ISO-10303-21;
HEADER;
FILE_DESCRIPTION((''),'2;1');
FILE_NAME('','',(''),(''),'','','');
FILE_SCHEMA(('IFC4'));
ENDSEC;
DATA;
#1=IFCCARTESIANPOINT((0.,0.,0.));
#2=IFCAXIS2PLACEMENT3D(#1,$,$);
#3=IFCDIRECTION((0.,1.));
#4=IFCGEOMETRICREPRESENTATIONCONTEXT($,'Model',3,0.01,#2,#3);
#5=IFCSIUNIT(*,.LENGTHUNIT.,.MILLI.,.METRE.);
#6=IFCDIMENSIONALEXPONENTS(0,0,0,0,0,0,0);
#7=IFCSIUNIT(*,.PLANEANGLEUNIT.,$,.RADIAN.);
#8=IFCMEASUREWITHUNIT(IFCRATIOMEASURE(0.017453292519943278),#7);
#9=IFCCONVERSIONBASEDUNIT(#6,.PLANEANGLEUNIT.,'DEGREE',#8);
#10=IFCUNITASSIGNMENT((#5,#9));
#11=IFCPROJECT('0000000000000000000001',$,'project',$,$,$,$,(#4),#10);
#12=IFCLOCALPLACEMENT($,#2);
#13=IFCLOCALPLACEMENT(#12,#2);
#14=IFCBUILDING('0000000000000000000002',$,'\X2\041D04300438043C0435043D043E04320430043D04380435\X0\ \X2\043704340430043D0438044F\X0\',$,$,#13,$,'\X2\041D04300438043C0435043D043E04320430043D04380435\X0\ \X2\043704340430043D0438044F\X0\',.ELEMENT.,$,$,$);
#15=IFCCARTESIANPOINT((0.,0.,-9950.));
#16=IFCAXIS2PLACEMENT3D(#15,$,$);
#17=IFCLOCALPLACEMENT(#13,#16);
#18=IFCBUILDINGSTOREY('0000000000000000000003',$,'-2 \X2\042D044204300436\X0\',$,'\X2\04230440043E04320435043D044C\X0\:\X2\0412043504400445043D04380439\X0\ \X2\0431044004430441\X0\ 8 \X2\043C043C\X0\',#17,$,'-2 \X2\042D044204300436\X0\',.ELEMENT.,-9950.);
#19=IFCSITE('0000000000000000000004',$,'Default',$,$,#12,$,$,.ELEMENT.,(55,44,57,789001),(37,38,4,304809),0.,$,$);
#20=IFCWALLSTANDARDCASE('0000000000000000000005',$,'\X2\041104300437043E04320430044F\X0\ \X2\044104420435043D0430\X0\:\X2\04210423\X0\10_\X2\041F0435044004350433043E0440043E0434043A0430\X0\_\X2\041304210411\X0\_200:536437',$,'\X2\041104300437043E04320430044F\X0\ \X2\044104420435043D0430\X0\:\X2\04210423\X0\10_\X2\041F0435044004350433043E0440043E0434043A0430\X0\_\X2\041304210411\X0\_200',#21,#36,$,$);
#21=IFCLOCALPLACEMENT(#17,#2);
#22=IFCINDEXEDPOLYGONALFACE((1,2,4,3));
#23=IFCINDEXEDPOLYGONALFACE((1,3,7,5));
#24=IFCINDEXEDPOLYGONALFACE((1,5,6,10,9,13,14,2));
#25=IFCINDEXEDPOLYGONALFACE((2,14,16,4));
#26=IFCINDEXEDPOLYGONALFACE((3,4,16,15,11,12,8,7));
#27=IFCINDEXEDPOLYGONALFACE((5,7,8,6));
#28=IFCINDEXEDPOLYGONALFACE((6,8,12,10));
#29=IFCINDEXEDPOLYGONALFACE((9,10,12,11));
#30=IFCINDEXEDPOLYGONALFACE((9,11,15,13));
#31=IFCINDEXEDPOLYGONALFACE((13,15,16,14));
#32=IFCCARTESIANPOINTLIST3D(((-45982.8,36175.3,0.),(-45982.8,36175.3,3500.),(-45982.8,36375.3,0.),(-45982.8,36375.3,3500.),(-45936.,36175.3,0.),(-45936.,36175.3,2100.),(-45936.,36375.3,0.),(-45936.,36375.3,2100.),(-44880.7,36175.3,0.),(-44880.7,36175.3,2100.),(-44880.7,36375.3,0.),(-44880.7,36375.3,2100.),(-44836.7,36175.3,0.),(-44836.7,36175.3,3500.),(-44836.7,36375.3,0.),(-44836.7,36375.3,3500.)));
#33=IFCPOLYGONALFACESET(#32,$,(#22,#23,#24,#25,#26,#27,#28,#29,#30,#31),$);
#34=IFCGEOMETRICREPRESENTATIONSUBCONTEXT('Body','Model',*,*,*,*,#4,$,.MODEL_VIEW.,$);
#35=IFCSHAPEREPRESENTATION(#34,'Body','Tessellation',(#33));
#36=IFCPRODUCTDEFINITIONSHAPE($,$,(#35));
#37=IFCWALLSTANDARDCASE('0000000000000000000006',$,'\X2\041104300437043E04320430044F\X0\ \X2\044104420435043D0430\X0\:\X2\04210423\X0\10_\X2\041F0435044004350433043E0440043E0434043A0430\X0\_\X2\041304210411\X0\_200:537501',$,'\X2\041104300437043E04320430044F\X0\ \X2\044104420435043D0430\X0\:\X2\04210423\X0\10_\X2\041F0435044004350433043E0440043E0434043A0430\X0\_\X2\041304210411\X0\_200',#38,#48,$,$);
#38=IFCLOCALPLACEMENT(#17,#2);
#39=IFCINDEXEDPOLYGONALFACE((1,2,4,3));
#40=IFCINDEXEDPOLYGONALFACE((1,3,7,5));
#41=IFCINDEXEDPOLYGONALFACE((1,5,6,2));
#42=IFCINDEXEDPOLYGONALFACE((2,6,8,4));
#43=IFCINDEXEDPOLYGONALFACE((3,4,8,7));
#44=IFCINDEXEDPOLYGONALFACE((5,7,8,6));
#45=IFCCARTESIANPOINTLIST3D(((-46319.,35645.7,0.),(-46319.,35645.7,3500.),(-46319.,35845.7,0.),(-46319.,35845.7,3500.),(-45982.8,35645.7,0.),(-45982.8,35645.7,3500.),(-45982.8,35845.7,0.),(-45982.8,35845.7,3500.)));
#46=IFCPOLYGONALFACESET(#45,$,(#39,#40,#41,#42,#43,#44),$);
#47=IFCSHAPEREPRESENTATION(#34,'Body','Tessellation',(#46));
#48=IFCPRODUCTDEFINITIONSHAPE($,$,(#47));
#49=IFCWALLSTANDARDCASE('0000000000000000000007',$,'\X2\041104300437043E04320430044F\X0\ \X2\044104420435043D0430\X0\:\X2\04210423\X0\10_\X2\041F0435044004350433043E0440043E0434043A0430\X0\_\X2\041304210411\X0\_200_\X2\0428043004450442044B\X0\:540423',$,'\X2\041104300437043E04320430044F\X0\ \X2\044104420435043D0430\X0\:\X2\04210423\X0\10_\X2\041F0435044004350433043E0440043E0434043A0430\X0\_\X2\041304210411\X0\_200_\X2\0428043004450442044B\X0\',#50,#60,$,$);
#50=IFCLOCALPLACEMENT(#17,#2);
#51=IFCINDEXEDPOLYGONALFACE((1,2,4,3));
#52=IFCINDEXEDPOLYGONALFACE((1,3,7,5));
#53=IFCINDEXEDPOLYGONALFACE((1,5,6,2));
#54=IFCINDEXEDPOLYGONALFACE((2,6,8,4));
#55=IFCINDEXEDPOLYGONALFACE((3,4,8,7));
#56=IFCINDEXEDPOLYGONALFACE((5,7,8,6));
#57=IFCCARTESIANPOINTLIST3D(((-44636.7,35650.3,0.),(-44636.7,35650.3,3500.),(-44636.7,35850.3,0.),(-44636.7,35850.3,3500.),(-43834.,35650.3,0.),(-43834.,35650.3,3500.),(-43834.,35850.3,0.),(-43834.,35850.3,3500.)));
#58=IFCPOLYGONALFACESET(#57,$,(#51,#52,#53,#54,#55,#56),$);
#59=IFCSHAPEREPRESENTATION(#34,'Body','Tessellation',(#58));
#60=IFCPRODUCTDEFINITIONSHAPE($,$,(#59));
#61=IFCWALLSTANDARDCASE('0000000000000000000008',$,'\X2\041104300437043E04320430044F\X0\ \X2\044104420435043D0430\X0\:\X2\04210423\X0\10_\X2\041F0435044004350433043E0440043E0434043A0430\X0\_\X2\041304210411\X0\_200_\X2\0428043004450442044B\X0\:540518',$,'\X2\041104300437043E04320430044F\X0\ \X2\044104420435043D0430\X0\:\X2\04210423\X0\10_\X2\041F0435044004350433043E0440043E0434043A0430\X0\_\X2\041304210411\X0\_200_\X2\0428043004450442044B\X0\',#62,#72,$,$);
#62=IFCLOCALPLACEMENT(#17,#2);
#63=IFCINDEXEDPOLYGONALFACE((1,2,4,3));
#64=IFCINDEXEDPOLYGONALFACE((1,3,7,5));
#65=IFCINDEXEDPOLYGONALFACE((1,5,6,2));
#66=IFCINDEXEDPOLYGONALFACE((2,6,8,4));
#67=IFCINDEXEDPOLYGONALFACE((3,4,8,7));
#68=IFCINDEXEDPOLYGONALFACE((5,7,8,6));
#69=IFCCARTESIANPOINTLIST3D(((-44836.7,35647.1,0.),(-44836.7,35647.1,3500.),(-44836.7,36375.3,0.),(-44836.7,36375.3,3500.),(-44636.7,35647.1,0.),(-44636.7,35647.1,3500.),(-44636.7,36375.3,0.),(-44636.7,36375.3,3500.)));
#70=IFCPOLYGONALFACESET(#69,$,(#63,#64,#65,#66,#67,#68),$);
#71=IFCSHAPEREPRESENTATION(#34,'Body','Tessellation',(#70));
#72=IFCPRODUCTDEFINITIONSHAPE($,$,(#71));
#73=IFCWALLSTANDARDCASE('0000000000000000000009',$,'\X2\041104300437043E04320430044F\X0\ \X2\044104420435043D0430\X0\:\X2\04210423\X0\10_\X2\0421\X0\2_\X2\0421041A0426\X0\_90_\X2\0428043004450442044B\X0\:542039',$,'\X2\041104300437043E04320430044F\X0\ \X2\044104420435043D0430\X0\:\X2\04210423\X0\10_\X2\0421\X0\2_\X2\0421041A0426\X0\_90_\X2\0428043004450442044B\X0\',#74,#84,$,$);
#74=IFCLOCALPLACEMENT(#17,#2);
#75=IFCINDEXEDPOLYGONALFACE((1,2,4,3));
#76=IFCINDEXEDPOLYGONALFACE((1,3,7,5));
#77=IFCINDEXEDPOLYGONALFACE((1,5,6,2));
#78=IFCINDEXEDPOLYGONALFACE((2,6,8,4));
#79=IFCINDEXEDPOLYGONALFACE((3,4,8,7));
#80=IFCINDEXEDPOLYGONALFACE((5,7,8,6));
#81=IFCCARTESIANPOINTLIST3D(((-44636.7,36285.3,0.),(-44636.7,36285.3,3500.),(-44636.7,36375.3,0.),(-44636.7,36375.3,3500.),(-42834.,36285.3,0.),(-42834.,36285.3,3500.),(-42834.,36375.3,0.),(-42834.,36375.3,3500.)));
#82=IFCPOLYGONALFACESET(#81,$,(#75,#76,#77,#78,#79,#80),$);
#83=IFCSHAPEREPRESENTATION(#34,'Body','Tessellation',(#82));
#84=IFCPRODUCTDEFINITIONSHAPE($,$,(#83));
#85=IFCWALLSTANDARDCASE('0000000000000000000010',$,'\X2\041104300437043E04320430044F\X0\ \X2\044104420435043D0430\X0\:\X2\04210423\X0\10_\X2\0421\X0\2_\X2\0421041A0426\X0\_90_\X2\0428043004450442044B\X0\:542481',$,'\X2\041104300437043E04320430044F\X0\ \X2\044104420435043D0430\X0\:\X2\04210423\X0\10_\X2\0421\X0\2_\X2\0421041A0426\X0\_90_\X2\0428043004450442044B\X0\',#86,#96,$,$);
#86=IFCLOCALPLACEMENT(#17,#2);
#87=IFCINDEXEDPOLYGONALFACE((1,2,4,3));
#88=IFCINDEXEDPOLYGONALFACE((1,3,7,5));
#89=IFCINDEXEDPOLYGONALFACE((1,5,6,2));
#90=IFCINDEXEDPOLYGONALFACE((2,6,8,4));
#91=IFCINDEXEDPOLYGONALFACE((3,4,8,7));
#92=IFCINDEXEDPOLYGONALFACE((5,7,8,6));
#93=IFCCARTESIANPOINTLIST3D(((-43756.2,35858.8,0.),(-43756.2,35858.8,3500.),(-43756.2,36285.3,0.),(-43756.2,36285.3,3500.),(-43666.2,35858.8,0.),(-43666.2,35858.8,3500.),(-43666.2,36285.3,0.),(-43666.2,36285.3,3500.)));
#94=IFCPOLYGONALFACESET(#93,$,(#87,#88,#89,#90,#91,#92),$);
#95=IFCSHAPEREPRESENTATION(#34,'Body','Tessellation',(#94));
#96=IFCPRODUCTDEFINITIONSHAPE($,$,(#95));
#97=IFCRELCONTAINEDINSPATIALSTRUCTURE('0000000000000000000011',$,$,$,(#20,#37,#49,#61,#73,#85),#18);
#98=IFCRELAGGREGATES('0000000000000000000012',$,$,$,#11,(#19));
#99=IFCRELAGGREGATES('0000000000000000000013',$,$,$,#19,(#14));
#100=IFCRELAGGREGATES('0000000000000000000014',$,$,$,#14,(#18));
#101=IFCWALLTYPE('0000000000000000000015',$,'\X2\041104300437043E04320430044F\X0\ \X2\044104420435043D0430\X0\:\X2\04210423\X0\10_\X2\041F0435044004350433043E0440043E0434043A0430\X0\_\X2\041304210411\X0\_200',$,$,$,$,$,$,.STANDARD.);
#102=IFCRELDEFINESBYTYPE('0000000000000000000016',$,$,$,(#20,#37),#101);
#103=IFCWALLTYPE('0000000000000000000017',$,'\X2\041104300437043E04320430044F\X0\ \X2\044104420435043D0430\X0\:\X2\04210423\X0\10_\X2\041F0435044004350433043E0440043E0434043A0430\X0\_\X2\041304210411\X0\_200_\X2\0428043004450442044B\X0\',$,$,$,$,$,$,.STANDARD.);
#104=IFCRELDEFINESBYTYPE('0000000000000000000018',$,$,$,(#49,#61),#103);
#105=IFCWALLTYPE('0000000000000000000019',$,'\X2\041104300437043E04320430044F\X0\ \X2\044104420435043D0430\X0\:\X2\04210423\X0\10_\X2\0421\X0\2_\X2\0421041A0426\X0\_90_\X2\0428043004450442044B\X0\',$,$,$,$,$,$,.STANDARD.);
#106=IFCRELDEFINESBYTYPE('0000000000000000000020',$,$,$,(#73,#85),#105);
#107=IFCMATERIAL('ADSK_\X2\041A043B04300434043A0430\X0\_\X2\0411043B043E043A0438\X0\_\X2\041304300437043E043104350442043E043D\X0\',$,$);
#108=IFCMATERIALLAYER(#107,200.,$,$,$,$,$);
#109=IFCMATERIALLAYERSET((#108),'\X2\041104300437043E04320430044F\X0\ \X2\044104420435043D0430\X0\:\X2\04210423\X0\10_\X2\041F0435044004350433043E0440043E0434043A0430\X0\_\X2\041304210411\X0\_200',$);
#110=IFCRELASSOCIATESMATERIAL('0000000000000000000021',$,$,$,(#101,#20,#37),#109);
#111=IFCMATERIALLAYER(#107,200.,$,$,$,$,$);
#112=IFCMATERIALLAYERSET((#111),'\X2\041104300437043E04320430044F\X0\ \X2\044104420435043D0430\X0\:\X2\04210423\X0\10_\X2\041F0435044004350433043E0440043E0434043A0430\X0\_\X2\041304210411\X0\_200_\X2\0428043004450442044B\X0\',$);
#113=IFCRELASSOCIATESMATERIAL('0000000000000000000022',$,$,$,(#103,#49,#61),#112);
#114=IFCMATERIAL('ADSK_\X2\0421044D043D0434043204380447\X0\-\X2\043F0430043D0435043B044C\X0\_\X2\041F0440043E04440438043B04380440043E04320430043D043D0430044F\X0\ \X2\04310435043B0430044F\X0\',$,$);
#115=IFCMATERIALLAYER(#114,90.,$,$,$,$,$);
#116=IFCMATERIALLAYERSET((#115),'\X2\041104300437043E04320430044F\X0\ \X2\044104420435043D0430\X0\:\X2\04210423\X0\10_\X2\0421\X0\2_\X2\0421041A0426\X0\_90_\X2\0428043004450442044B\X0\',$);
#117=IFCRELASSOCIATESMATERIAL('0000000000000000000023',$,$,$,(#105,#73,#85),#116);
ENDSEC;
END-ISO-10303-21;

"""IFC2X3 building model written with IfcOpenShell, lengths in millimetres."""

from ifc_helpers import new_model, entity, si_unit, converted_unit, direction, frame, frame_2d, origin, place, context, subcontext, project, spatial, rectangle, extrude, material, layer, layer_set, layer_usage, type_object, element, save


model = new_model("IFC2X3")

# Units and contexts
model_context = context("Model", 3, precision=0.01, world=origin(), true_north=direction((0.0, 1.0)))
body_context = subcontext(model_context, "Body", "Model", "MODEL_VIEW")
ifc_project = project(units=[si_unit("LENGTHUNIT", "METRE", prefix="MILLI"), converted_unit("PLANEANGLEUNIT", "DEGREE", entity("IfcRatioMeasure", 0.017453292519943278), si_unit("PLANEANGLEUNIT", "RADIAN"), dimensions=[0, 0, 0, 0, 0, 0, 0])], contexts=[model_context])

# Site, building, storey
site_placement = place(None, origin())
site = spatial("IfcSite", under=ifc_project, at=site_placement, Name="Default", CompositionType="ELEMENT", RefLatitude=(55, 44, 57, 789001), RefLongitude=(37, 38, 4, 304809), RefElevation=0.0)
building_placement = place(site_placement, origin())
building = spatial("IfcBuilding", under=site, at=building_placement, Name="Наименование здания", LongName="Наименование здания", CompositionType="ELEMENT")
storey_placement = place(building_placement, frame((0.0, 0.0, -9950.0)))
storey = spatial("IfcBuildingStorey", under=building, at=storey_placement, Name="-2 Этаж", ObjectType="Уровень:Верхний брус 8 мм", LongName="-2 Этаж", CompositionType="ELEMENT", Elevation=-9950.0)

# Shared definitions
ifc_material_1 = material(Name="ADSK_Сэндвич-панель_Профилированная белая")

# Shared definitions
ifc_material_2 = material(Name="ADSK_Кладка_Блоки_Газобетон")
ifc_layer_1 = layer(ifc_material_2, 200.0)
ifc_layer_set_1 = layer_set([ifc_layer_1], Name="Базовая стена:СУ10_Перегородка_ГСБ_200")
ifc_layer_usage_1 = layer_usage(ifc_layer_set_1, "AXIS2", "NEGATIVE", 100.0)
wall_type_1 = type_object("IfcWallType", Name="Базовая стена:СУ10_Перегородка_ГСБ_200", PredefinedType="STANDARD", material=ifc_layer_set_1)

# Wall, opening
wall_1_placement = place(storey_placement, frame((-44836.7, 36275.3, 0.0), z_axis=(0.0, 0.0, 1.0), x_axis=(-1.0, 0.0, 0.0)))
wall_1 = element("IfcWallStandardCase", 1, at=wall_1_placement, inside=storey, type_object=wall_type_1, material=ifc_layer_usage_1, Name="Базовая стена:СУ10_Перегородка_ГСБ_200:536437", ObjectType="Базовая стена:СУ10_Перегородка_ГСБ_200", context=body_context, shape_type="SweptSolid", body=[
    extrude(rectangle(XDim=1146.2, YDim=200.0, at=frame_2d((573.1, 0.0), x_axis=(1.0, 0.0))), origin(), (0.0, 0.0, 1.0), 3500.0),
])
opening_1_placement = place(wall_1_placement, origin())
element("IfcOpeningElement", 2, at=opening_1_placement, cuts=wall_1, ObjectType="Opening", context=body_context, shape_type="SweptSolid", body=[
    extrude(rectangle(XDim=2100.0, YDim=1055.4, at=frame_2d((0.0, 0.0), x_axis=(1.0, 0.0))), frame((571.7, -100.0, 1050.0), z_axis=(0.0, 1.0, 0.0), x_axis=(0.0, 0.0, -1.0)), (0.0, 0.0, 1.0), 200.0),
])

# Walls
wall_2_placement = place(storey_placement, frame((-45982.8, 35745.7, 0.0), z_axis=(0.0, 0.0, 1.0), x_axis=(-1.0, 0.0, 0.0)))
element("IfcWallStandardCase", 3, at=wall_2_placement, inside=storey, type_object=wall_type_1, material=ifc_layer_usage_1, Name="Базовая стена:СУ10_Перегородка_ГСБ_200:537501", ObjectType="Базовая стена:СУ10_Перегородка_ГСБ_200", context=body_context, shape_type="SweptSolid", body=[
    extrude(rectangle(XDim=336.1, YDim=200.0, at=frame_2d((168.1, 0.0), x_axis=(-1.0, 0.0))), origin(), (0.0, 0.0, 1.0), 3500.0),
])
ifc_layer_2 = layer(ifc_material_2, 200.0)
ifc_layer_set_2 = layer_set([ifc_layer_2], Name="Базовая стена:СУ10_Перегородка_ГСБ_200_Шахты")
ifc_layer_usage_2 = layer_usage(ifc_layer_set_2, "AXIS2", "NEGATIVE", 100.0)
wall_type_2 = type_object("IfcWallType", Name="Базовая стена:СУ10_Перегородка_ГСБ_200_Шахты", PredefinedType="STANDARD", material=ifc_layer_set_2)
wall_3_placement = place(storey_placement, frame((-44636.7, 35750.3, 0.0)))
element("IfcWallStandardCase", 4, at=wall_3_placement, inside=storey, type_object=wall_type_2, material=ifc_layer_usage_2, Name="Базовая стена:СУ10_Перегородка_ГСБ_200_Шахты:540423", ObjectType="Базовая стена:СУ10_Перегородка_ГСБ_200_Шахты", context=body_context, shape_type="SweptSolid", body=[
    extrude(rectangle(XDim=802.7, YDim=200.0, at=frame_2d((401.4, 0.0), x_axis=(-1.0, 0.0))), origin(), (0.0, 0.0, 1.0), 3500.0),
])
wall_4_placement = place(storey_placement, frame((-44736.7, 35647.1, 0.0), z_axis=(0.0, 0.0, 1.0), x_axis=(0.0, 1.0, 0.0)))
element("IfcWallStandardCase", 5, at=wall_4_placement, inside=storey, type_object=wall_type_2, material=ifc_layer_usage_2, Name="Базовая стена:СУ10_Перегородка_ГСБ_200_Шахты:540518", ObjectType="Базовая стена:СУ10_Перегородка_ГСБ_200_Шахты", context=body_context, shape_type="SweptSolid", body=[
    extrude(rectangle(XDim=728.1, YDim=200.0, at=frame_2d((364.1, 0.0), x_axis=(-1.0, 0.0))), origin(), (0.0, 0.0, 1.0), 3500.0),
])
ifc_layer_3 = layer(ifc_material_1, 90.0)
ifc_layer_set_3 = layer_set([ifc_layer_3], Name="Базовая стена:СУ10_С2_СКЦ_90_Шахты")
ifc_layer_usage_3 = layer_usage(ifc_layer_set_3, "AXIS2", "NEGATIVE", 45.0)
wall_type_3 = type_object("IfcWallType", Name="Базовая стена:СУ10_С2_СКЦ_90_Шахты", PredefinedType="STANDARD", material=ifc_layer_set_3)
wall_5_placement = place(storey_placement, frame((-42834.0, 36330.3, 0.0), z_axis=(0.0, 0.0, 1.0), x_axis=(-1.0, 0.0, 0.0)))
element("IfcWallStandardCase", 6, at=wall_5_placement, inside=storey, type_object=wall_type_3, material=ifc_layer_usage_3, Name="Базовая стена:СУ10_С2_СКЦ_90_Шахты:542039", ObjectType="Базовая стена:СУ10_С2_СКЦ_90_Шахты", context=body_context, shape_type="SweptSolid", body=[
    extrude(rectangle(XDim=1802.7, YDim=90.0, at=frame_2d((901.3, 0.0), x_axis=(-1.0, 0.0))), origin(), (0.0, 0.0, 1.0), 3500.0),
])
wall_6_placement = place(storey_placement, frame((-43711.2, 35858.8, 0.0), z_axis=(0.0, 0.0, 1.0), x_axis=(0.0, 1.0, 0.0)))
element("IfcWallStandardCase", 7, at=wall_6_placement, inside=storey, type_object=wall_type_3, material=ifc_layer_usage_3, Name="Базовая стена:СУ10_С2_СКЦ_90_Шахты:542481", ObjectType="Базовая стена:СУ10_С2_СКЦ_90_Шахты", context=body_context, shape_type="SweptSolid", body=[
    extrude(rectangle(XDim=426.5, YDim=90.0, at=frame_2d((213.2, 0.0), x_axis=(-1.0, 0.0))), origin(), (0.0, 0.0, 1.0), 3500.0),
])

save(model, "model.ifc")
